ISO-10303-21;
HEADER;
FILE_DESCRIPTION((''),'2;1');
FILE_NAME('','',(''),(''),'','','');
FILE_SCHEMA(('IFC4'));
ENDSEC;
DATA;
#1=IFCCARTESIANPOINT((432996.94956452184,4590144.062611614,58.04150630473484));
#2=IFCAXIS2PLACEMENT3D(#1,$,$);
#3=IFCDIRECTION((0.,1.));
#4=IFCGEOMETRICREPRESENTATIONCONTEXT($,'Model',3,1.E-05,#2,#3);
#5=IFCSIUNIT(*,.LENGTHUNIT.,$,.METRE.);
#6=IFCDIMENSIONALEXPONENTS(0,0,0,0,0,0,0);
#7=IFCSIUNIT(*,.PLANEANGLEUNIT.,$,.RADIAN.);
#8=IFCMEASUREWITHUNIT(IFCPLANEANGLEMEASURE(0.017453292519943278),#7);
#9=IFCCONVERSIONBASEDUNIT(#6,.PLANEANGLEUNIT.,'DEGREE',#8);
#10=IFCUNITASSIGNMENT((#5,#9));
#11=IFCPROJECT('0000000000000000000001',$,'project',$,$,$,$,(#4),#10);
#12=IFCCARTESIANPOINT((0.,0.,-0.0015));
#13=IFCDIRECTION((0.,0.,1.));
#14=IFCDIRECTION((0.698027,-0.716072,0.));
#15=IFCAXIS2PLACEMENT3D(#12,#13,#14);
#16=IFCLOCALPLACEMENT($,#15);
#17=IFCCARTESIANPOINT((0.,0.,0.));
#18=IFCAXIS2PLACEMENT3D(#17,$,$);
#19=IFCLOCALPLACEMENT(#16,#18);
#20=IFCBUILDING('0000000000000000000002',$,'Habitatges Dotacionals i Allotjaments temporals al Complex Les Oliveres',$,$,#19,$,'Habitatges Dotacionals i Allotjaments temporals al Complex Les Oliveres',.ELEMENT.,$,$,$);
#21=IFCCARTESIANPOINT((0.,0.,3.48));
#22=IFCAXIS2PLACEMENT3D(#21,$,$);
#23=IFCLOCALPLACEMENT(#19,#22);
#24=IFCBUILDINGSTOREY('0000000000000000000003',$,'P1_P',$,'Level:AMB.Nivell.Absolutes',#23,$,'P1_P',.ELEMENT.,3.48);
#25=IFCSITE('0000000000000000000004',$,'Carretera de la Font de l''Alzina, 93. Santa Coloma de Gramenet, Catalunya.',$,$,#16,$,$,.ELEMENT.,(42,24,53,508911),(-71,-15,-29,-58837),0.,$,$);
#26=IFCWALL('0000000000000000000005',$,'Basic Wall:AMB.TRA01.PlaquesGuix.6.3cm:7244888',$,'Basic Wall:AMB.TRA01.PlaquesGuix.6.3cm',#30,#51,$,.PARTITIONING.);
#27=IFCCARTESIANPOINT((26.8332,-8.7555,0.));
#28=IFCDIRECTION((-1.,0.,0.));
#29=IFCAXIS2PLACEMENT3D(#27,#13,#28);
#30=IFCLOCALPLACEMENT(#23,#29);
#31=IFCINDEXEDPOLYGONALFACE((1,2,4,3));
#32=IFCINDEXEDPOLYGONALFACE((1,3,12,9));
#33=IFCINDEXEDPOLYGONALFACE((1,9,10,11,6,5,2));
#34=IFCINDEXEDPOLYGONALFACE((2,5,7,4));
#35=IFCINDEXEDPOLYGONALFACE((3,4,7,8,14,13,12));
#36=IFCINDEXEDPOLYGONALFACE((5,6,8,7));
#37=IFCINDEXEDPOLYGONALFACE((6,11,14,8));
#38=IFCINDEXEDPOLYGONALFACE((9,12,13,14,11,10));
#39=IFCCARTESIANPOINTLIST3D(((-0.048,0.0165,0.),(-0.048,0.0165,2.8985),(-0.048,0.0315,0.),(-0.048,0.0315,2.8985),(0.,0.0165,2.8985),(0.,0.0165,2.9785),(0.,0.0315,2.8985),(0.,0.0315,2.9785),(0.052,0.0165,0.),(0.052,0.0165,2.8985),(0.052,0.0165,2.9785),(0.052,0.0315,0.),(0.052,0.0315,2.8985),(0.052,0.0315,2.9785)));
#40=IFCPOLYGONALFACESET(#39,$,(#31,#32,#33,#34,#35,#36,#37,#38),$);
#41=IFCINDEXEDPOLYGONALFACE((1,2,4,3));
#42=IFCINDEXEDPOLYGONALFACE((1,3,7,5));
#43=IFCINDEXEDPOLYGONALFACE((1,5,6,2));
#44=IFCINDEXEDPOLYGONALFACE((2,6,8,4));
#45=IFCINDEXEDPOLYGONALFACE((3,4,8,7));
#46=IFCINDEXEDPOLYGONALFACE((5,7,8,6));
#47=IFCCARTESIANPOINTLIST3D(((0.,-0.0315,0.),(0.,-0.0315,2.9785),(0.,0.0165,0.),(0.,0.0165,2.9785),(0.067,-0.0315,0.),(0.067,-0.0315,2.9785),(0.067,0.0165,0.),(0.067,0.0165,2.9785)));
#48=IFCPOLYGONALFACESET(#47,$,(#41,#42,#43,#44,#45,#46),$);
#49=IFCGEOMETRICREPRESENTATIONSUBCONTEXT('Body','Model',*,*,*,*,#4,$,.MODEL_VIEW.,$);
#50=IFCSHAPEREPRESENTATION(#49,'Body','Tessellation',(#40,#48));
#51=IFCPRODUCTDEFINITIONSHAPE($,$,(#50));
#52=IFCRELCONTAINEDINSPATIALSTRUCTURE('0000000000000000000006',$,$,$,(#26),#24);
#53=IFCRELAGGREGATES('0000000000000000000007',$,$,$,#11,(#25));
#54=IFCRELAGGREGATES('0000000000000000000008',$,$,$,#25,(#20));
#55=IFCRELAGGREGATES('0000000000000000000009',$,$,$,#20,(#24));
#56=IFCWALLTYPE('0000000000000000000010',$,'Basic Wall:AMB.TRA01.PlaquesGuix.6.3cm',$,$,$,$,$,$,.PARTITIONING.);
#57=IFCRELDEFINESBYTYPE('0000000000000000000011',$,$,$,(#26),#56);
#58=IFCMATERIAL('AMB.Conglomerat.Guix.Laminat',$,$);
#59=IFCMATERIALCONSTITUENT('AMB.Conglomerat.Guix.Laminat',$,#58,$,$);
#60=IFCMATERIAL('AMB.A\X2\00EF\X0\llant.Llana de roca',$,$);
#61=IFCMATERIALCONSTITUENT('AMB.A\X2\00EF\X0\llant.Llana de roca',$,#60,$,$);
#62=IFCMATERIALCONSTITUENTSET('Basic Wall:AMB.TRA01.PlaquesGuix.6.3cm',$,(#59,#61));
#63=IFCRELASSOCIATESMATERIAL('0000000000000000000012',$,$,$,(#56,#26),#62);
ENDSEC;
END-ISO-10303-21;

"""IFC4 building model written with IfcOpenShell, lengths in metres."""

from ifc_helpers import new_model, entity, si_unit, converted_unit, direction, frame, origin, place, context, subcontext, project, spatial, indexed_curve, outline, extrude, material, constituent, constituent_set, type_object, element, save


model = new_model("IFC4")

# Units and contexts
model_context = context("Model", 3, precision=1e-05, world=frame((432996.94956452184, 4590144.062611614, 58.04150630473484)), true_north=direction((0.0, 1.0)))
body_context = subcontext(model_context, "Body", "Model", "MODEL_VIEW")
ifc_project = project(units=[si_unit("LENGTHUNIT", "METRE"), converted_unit("PLANEANGLEUNIT", "DEGREE", entity("IfcPlaneAngleMeasure", 0.017453292519943278), si_unit("PLANEANGLEUNIT", "RADIAN"), dimensions=[0, 0, 0, 0, 0, 0, 0])], contexts=[model_context])

# Site, building, storey
site_placement = place(None, frame((0.0, 0.0, -0.0015), z_axis=(0.0, 0.0, 1.0), x_axis=(0.698027, -0.716072, 0.0)))
site = spatial("IfcSite", under=ifc_project, at=site_placement, Name="Carretera de la Font de l'Alzina, 93. Santa Coloma de Gramenet, Catalunya.", CompositionType="ELEMENT", RefLatitude=(42, 24, 53, 508911), RefLongitude=(-71, -15, -29, -58837), RefElevation=0.0)
building_placement = place(site_placement, origin())
building = spatial("IfcBuilding", under=site, at=building_placement, Name="Habitatges Dotacionals i Allotjaments temporals al Complex Les Oliveres", LongName="Habitatges Dotacionals i Allotjaments temporals al Complex Les Oliveres", CompositionType="ELEMENT")
storey_placement = place(building_placement, frame((0.0, 0.0, 3.48)))
storey = spatial("IfcBuildingStorey", under=building, at=storey_placement, Name="P1_P", ObjectType="Level:AMB.Nivell.Absolutes", LongName="P1_P", CompositionType="ELEMENT", Elevation=3.48)

# Wall
ifc_material_1 = material(Name="AMB.Conglomerat.Guix.Laminat")
ifc_constituent_1 = constituent(ifc_material_1, Name="AMB.Conglomerat.Guix.Laminat")
ifc_material_2 = material(Name="AMB.Aïllant.Llana de roca")
ifc_constituent_2 = constituent(ifc_material_2, Name="AMB.Aïllant.Llana de roca")
ifc_constituent_set = constituent_set(constituents=[ifc_constituent_1, ifc_constituent_2], Name="Basic Wall:AMB.TRA01.PlaquesGuix.6.3cm")
wall_type = type_object("IfcWallType", Name="Basic Wall:AMB.TRA01.PlaquesGuix.6.3cm", PredefinedType="PARTITIONING", material=ifc_constituent_set)
wall_1_placement = place(storey_placement, frame((26.8332, -8.7555, 0.0), z_axis=(0.0, 0.0, 1.0), x_axis=(-1.0, 0.0, 0.0)))
element("IfcWall", 1, at=wall_1_placement, inside=storey, type_object=wall_type, material=ifc_constituent_set, Name="Basic Wall:AMB.TRA01.PlaquesGuix.6.3cm:7244888", ObjectType="Basic Wall:AMB.TRA01.PlaquesGuix.6.3cm", PredefinedType="PARTITIONING", context=body_context, shape_type="SweptSolid", body=[
    extrude(outline(indexed_curve([(-2.0932, -0.0435), (0.8053, -0.0435), (0.8853, -0.0435), (0.8853, 0.0086), (0.8053, 0.0086), (0.8053, 0.0566), (-2.0932, 0.0566), (-2.0932, -0.0435)], self_intersect=False)), frame((0.0086, 0.0315, 2.0932), z_axis=(0.0, -1.0, 0.0), x_axis=(0.0, 0.0, 1.0)), (0.0, 0.0, 1.0), 0.015),
    extrude(outline(indexed_curve([(-0.024, -0.0335), (0.024, -0.0335), (0.024, 0.0335), (-0.024, 0.0335), (-0.024, -0.0335)], self_intersect=False)), frame((0.0335, -0.0075, 0.0), z_axis=(0.0, 0.0, 1.0), x_axis=(0.0, -1.0, 0.0)), (0.0, 0.0, 1.0), 2.9785),
])

save(model, "model.ifc")
